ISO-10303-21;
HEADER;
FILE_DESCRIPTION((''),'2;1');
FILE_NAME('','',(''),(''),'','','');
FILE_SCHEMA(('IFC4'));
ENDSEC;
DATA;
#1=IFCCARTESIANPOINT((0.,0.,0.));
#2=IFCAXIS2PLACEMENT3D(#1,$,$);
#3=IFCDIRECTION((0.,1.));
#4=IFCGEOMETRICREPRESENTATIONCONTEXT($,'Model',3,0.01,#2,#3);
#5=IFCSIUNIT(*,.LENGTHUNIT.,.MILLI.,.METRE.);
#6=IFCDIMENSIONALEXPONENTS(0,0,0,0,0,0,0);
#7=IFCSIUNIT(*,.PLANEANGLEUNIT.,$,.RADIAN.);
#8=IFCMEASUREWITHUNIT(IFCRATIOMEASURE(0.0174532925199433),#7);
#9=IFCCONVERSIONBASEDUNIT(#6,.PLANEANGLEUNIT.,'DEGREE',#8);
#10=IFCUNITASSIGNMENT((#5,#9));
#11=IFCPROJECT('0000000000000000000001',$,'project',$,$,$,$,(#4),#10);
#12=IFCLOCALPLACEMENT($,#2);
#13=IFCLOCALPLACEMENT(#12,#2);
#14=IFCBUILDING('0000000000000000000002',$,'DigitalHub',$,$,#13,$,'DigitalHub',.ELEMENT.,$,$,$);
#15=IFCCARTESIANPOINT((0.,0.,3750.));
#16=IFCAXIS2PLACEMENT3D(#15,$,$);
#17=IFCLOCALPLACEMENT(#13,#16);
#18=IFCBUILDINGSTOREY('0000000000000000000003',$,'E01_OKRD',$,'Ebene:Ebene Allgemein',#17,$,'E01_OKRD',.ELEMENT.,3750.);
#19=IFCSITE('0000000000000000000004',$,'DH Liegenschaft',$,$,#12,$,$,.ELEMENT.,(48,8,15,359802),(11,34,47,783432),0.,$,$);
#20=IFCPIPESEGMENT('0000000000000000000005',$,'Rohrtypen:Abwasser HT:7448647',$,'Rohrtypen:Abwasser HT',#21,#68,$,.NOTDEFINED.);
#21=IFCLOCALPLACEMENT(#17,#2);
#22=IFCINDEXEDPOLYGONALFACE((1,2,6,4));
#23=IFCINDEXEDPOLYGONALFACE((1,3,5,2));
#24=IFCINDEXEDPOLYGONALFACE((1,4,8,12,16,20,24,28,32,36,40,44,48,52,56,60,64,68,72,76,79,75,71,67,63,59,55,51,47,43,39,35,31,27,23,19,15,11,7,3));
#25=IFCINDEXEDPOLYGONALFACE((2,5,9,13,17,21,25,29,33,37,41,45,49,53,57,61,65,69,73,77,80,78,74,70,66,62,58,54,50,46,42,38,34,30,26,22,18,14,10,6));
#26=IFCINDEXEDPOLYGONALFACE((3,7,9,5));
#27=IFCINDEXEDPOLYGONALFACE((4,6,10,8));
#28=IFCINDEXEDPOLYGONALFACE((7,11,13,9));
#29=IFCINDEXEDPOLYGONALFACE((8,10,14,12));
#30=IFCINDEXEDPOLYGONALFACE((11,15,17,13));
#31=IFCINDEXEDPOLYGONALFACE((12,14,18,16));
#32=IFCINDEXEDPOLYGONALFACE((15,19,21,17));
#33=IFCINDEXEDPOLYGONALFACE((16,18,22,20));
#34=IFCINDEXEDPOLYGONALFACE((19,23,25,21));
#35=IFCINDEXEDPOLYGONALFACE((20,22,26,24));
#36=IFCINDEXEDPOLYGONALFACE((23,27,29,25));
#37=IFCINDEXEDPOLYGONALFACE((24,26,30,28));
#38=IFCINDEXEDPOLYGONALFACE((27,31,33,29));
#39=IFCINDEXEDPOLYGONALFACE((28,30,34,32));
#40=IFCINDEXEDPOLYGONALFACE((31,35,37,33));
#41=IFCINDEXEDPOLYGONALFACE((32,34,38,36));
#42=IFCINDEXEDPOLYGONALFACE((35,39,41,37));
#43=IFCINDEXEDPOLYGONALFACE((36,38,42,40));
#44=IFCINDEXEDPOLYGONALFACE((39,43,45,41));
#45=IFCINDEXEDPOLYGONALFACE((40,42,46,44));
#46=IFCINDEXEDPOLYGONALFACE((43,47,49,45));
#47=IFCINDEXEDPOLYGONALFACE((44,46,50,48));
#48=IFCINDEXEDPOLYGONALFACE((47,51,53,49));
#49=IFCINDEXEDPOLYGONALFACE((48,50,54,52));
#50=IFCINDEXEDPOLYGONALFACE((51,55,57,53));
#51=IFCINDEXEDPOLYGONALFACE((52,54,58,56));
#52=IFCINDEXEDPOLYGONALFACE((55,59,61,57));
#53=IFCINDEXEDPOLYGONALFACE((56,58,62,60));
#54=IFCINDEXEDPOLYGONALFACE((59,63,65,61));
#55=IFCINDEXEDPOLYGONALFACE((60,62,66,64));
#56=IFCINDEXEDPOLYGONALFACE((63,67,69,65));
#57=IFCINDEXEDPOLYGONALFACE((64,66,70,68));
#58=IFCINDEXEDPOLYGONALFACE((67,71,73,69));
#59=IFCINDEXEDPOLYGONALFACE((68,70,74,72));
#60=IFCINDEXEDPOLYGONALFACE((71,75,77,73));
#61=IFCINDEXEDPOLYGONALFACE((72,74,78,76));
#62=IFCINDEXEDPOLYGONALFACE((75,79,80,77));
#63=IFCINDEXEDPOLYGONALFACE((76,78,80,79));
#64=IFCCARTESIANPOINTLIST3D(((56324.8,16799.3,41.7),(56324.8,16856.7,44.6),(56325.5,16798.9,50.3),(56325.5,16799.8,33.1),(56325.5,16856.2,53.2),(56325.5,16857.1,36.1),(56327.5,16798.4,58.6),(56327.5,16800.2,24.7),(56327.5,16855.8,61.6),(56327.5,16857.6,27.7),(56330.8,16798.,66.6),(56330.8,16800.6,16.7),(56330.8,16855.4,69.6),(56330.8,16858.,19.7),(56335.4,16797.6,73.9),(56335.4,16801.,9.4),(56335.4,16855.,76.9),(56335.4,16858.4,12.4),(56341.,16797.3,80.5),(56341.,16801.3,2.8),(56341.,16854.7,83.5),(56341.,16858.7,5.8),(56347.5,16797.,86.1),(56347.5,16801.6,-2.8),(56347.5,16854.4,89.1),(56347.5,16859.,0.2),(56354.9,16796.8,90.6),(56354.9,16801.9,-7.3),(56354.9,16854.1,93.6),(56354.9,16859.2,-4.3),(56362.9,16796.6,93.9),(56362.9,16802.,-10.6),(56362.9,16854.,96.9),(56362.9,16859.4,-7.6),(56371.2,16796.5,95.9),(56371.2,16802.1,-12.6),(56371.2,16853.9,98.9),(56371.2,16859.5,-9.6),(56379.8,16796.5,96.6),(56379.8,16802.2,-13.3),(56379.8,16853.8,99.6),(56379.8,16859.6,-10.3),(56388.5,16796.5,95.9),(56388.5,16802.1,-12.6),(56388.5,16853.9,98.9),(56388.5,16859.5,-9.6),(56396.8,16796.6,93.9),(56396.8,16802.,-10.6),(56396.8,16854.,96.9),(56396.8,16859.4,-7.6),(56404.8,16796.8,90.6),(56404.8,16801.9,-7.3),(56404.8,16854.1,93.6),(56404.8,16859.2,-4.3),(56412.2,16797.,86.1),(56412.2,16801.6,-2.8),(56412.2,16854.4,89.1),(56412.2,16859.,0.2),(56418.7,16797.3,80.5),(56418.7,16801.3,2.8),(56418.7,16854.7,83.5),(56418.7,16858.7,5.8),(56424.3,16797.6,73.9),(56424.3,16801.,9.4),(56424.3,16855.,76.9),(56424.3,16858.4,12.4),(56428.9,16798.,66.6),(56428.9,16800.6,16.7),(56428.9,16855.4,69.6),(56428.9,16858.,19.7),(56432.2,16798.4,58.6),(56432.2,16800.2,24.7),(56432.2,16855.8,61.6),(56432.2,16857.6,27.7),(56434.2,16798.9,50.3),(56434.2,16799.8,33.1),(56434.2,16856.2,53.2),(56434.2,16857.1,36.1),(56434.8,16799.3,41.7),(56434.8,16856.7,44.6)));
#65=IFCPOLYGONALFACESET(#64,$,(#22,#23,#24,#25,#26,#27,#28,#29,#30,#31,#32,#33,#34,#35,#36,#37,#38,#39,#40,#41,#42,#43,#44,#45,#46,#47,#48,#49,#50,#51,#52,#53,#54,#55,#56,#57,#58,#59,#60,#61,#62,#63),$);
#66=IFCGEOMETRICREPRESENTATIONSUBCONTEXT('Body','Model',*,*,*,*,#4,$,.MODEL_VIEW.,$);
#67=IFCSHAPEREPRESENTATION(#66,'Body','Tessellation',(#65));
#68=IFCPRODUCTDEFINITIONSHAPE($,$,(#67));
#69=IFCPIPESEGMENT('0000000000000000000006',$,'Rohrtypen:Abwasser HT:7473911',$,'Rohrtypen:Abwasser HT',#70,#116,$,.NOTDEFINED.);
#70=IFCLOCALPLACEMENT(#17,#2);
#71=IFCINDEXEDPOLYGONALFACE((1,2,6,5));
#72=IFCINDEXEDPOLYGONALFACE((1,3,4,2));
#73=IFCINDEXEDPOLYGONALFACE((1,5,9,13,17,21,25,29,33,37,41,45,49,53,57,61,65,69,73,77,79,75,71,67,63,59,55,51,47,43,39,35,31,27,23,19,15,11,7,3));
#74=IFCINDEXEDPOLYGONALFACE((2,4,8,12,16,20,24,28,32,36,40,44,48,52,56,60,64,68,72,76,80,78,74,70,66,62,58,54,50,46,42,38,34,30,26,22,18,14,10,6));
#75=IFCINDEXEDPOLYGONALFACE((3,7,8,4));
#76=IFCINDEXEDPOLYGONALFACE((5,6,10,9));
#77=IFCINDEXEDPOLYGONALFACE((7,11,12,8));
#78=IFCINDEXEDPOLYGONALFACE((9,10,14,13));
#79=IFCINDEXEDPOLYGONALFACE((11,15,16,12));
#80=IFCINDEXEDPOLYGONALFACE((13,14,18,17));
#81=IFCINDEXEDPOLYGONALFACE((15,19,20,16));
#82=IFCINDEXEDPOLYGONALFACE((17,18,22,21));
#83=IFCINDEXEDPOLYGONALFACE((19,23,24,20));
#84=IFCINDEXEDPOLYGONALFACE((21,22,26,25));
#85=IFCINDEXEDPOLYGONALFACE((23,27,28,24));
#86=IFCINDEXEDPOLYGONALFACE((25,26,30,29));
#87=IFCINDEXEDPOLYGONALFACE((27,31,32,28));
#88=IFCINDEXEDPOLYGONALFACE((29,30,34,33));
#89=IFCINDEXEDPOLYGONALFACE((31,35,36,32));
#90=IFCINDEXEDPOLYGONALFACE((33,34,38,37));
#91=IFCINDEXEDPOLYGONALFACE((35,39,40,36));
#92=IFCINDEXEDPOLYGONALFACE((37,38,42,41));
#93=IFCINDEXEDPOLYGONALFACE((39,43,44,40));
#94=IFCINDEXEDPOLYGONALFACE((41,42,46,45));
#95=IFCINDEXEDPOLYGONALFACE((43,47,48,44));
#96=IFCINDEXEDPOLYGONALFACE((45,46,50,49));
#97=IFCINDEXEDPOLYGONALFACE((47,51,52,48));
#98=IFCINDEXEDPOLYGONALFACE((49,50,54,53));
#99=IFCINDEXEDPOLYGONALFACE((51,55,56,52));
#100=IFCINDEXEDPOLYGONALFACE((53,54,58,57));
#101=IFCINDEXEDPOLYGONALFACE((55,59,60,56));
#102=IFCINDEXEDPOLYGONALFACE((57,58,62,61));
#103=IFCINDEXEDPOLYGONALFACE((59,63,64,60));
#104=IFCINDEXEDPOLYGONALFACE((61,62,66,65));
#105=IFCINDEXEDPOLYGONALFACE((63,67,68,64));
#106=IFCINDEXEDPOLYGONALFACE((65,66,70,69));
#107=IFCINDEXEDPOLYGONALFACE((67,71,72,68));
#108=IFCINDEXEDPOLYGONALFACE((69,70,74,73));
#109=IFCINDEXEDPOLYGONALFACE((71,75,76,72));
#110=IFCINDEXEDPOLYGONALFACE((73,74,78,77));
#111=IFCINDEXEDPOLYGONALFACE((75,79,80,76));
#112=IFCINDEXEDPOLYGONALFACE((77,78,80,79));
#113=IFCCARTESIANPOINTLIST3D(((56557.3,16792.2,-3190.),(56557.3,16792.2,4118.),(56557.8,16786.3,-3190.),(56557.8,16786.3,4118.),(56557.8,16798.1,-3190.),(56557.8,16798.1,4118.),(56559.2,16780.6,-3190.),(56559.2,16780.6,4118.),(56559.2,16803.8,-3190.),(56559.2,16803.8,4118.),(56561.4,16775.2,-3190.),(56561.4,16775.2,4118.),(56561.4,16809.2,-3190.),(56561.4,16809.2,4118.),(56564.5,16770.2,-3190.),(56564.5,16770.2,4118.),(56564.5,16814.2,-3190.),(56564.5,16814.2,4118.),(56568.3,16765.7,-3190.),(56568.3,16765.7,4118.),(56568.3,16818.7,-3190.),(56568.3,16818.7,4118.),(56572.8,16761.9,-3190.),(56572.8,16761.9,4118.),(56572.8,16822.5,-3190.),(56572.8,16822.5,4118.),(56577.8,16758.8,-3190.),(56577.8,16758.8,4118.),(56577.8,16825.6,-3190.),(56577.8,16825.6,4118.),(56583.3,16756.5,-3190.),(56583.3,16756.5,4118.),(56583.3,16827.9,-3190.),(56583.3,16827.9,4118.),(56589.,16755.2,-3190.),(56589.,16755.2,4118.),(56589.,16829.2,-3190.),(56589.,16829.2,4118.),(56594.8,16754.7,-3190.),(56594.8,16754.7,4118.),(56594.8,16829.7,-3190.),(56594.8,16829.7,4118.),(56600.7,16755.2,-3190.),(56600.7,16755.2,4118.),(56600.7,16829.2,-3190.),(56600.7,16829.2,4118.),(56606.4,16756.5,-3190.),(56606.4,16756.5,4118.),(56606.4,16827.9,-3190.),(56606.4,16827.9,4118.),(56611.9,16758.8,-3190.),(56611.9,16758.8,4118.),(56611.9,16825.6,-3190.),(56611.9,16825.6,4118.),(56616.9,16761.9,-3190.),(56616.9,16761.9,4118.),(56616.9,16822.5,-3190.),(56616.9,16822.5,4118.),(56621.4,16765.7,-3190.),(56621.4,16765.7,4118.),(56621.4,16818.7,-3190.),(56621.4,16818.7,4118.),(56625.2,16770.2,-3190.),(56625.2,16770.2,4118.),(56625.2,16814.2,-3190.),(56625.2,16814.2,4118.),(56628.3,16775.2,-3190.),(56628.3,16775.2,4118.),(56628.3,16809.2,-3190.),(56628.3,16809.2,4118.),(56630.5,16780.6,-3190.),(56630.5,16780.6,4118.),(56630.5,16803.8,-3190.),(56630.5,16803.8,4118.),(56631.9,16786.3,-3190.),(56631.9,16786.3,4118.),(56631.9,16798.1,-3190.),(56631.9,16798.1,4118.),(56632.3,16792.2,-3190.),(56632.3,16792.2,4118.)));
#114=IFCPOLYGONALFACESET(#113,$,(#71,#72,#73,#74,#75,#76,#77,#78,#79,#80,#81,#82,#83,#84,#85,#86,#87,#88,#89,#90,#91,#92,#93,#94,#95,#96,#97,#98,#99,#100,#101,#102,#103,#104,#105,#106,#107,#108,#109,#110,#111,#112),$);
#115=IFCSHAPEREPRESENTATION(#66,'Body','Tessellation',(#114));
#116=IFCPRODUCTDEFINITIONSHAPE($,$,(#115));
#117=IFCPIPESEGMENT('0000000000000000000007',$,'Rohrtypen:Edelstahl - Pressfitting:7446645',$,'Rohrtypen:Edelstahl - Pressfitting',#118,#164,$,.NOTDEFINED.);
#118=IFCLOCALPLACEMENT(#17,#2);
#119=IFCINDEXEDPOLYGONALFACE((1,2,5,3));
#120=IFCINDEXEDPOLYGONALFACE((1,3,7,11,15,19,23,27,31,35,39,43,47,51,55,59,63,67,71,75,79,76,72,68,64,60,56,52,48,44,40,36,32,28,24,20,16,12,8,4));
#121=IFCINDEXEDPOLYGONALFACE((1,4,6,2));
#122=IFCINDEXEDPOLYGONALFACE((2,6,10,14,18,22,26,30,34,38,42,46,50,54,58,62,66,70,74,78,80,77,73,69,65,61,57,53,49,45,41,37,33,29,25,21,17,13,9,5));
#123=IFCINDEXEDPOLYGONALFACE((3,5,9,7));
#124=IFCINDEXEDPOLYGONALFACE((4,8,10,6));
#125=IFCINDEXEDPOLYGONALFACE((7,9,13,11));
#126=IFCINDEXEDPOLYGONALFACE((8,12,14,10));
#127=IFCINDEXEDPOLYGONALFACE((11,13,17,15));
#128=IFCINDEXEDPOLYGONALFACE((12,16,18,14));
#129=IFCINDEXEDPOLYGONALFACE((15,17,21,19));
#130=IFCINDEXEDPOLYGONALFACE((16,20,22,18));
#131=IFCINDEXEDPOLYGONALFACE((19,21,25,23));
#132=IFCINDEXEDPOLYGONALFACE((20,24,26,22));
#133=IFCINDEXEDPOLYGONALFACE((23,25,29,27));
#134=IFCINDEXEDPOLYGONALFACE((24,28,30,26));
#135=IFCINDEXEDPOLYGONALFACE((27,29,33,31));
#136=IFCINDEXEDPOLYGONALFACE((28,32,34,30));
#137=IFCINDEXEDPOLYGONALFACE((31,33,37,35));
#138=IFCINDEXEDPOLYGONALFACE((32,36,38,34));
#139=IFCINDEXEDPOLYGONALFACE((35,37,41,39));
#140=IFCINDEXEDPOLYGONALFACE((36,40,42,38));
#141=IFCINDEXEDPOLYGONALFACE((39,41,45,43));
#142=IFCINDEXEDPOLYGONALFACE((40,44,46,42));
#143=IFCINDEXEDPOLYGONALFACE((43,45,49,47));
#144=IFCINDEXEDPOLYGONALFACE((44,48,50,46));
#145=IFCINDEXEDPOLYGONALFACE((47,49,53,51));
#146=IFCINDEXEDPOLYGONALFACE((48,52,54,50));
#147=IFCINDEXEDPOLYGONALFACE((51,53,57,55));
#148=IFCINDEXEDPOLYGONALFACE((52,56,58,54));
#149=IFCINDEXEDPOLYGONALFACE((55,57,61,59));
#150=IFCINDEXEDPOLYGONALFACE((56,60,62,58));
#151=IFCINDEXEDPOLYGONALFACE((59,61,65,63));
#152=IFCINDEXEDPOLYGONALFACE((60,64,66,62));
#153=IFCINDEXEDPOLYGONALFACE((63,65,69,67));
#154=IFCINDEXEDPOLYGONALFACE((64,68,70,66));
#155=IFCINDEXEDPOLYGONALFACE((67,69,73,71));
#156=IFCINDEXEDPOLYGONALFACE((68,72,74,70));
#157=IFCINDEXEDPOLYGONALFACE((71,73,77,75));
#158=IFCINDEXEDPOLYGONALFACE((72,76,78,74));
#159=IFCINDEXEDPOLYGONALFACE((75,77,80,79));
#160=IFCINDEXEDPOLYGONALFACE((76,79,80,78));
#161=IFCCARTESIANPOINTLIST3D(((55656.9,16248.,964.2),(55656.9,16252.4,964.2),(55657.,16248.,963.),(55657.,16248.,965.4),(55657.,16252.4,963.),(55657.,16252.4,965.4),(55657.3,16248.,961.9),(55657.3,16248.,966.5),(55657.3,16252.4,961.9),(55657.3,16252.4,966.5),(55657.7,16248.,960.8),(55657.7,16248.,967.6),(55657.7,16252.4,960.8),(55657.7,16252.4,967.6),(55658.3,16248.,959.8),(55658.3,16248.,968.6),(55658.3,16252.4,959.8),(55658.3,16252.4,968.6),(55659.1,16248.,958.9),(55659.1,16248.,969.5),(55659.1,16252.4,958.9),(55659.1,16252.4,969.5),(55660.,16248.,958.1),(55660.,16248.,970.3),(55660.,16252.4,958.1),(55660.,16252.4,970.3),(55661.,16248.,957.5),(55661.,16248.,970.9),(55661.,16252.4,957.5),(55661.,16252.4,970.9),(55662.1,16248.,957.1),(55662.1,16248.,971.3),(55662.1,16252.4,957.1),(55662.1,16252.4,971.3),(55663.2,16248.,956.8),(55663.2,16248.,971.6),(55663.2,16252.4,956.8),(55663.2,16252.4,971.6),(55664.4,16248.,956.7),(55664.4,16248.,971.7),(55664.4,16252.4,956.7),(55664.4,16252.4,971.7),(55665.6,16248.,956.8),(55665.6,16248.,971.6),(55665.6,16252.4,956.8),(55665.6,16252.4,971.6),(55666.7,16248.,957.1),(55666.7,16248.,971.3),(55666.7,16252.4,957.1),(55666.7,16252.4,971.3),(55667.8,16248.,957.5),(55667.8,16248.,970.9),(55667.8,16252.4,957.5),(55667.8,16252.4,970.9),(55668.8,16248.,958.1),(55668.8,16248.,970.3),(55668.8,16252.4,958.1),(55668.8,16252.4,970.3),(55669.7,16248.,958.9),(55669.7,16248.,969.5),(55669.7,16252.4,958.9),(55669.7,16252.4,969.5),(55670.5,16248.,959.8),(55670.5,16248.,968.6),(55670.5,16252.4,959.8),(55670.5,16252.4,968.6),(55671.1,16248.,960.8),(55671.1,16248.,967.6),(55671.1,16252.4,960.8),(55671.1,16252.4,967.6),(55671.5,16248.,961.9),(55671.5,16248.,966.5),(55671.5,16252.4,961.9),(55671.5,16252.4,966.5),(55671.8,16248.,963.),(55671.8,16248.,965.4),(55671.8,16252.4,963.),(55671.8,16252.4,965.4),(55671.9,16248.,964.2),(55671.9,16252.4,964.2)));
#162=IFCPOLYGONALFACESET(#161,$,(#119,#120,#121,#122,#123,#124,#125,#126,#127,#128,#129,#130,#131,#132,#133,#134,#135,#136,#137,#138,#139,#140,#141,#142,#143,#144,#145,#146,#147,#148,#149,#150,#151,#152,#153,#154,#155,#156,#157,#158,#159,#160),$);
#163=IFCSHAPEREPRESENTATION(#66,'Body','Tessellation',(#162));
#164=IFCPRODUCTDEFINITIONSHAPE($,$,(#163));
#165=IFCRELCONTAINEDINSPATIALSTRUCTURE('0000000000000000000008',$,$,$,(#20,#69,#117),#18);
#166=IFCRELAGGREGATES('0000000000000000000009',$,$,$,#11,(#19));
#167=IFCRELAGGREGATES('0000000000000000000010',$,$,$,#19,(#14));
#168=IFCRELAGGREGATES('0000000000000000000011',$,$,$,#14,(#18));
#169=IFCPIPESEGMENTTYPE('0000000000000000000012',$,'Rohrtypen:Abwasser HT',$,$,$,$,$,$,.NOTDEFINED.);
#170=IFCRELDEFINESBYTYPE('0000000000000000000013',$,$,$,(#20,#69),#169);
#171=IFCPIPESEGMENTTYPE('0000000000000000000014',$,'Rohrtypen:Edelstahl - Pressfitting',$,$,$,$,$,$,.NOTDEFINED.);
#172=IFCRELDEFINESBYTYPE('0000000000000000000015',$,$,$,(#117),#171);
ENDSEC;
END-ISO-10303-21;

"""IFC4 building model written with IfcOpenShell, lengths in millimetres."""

from ifc_helpers import new_model, entity, si_unit, converted_unit, direction, frame, origin, place, context, subcontext, project, spatial, indexed_curve, outline, extrude, type_object, element, save


model = new_model("IFC4")

# Units and contexts
model_context = context("Model", 3, precision=0.01, world=origin(), true_north=direction((0.0, 1.0)))
body_context = subcontext(model_context, "Body", "Model", "MODEL_VIEW")
ifc_project = project(units=[si_unit("LENGTHUNIT", "METRE", prefix="MILLI"), converted_unit("PLANEANGLEUNIT", "DEGREE", entity("IfcRatioMeasure", 0.0174532925199433), si_unit("PLANEANGLEUNIT", "RADIAN"), dimensions=[0, 0, 0, 0, 0, 0, 0])], contexts=[model_context])

# Site, building, storey
site_placement = place(None, origin())
site = spatial("IfcSite", under=ifc_project, at=site_placement, Name="DH Liegenschaft", CompositionType="ELEMENT", RefLatitude=(48, 8, 15, 359802), RefLongitude=(11, 34, 47, 783432), RefElevation=0.0)
building_placement = place(site_placement, origin())
building = spatial("IfcBuilding", under=site, at=building_placement, Name="DigitalHub", LongName="DigitalHub", CompositionType="ELEMENT")
storey_placement = place(building_placement, frame((0.0, 0.0, 3750.0)))
storey = spatial("IfcBuildingStorey", under=building, at=storey_placement, Name="E01_OKRD", ObjectType="Ebene:Ebene Allgemein", LongName="E01_OKRD", CompositionType="ELEMENT", Elevation=3750.0)

# Pipe segments
pipe_segment_type_1 = type_object("IfcPipeSegmentType", Name="Rohrtypen:Abwasser HT", PredefinedType="NOTDEFINED")
pipe_segment_1_placement = place(storey_placement, frame((56323.3, 16794.9, -14.9)))
element("IfcPipeSegment", 1, at=pipe_segment_1_placement, inside=storey, type_object=pipe_segment_type_1, Name="Rohrtypen:Abwasser HT:7448647", ObjectType="Rohrtypen:Abwasser HT", PredefinedType="NOTDEFINED", context=body_context, shape_type="SweptSolid", body=[
    extrude(outline(indexed_curve([(55.0, 0.0), (54.3, 8.6), (52.3, 17.0), (49.0, 25.0), (44.5, 32.3), (38.9, 38.9), (32.3, 44.5), (25.0, 49.0), (17.0, 52.3), (8.6, 54.3), (0.0, 55.0), (-8.6, 54.3), (-17.0, 52.3), (-25.0, 49.0), (-32.3, 44.5), (-38.9, 38.9), (-44.5, 32.3), (-49.0, 25.0), (-52.3, 17.0), (-54.3, 8.6), (-55.0, 0.0), (-54.3, -8.6), (-52.3, -17.0), (-49.0, -25.0), (-44.5, -32.3), (-38.9, -38.9), (-32.3, -44.5), (-25.0, -49.0), (-17.0, -52.3), (-8.6, -54.3), (0.0, -55.0), (8.6, -54.3), (17.0, -52.3), (25.0, -49.0), (32.3, -44.5), (38.9, -38.9), (44.5, -32.3), (49.0, -25.0), (52.3, -17.0), (54.3, -8.6), (55.0, 0.0)], self_intersect=False)), frame((56.6, 4.5, 56.5), z_axis=(0.000001, 0.998647, 0.051999), x_axis=(-1.0, 0.000001, 0.0)), (0.0, 0.0, 1.0), 57.4),
])
pipe_segment_2_placement = place(storey_placement, frame((56555.8, 16753.1, -3190.0)))
element("IfcPipeSegment", 2, at=pipe_segment_2_placement, inside=storey, type_object=pipe_segment_type_1, Name="Rohrtypen:Abwasser HT:7473911", ObjectType="Rohrtypen:Abwasser HT", PredefinedType="NOTDEFINED", context=body_context, shape_type="SweptSolid", body=[
    extrude(outline(indexed_curve([(37.5, 0.0), (37.0, 5.9), (35.7, 11.6), (33.4, 17.0), (30.3, 22.0), (26.5, 26.5), (22.0, 30.3), (17.0, 33.4), (11.6, 35.7), (5.9, 37.0), (0.0, 37.5), (-5.9, 37.0), (-11.6, 35.7), (-17.0, 33.4), (-22.0, 30.3), (-26.5, 26.5), (-30.3, 22.0), (-33.4, 17.0), (-35.7, 11.6), (-37.0, 5.9), (-37.5, 0.0), (-37.0, -5.9), (-35.7, -11.6), (-33.4, -17.0), (-30.3, -22.0), (-26.5, -26.5), (-22.0, -30.3), (-17.0, -33.4), (-11.6, -35.7), (-5.9, -37.0), (0.0, -37.5), (5.9, -37.0), (11.6, -35.7), (17.0, -33.4), (22.0, -30.3), (26.5, -26.5), (30.3, -22.0), (33.4, -17.0), (35.7, -11.6), (37.0, -5.9), (37.5, 0.0)], self_intersect=False)), frame((39.1, 39.1, 0.0), z_axis=(0.0, 0.0, 1.0), x_axis=(-1.0, 0.0, 0.0)), (0.0, 0.0, 1.0), 7308.0),
])
pipe_segment_type_2 = type_object("IfcPipeSegmentType", Name="Rohrtypen:Edelstahl - Pressfitting", PredefinedType="NOTDEFINED")
pipe_segment_3_placement = place(storey_placement, frame((55655.3, 16248.0, 955.1)))
element("IfcPipeSegment", 3, at=pipe_segment_3_placement, inside=storey, type_object=pipe_segment_type_2, Name="Rohrtypen:Edelstahl - Pressfitting:7446645", ObjectType="Rohrtypen:Edelstahl - Pressfitting", PredefinedType="NOTDEFINED", context=body_context, shape_type="SweptSolid", body=[
    extrude(outline(indexed_curve([(7.5, 0.0), (7.4, 1.2), (7.1, 2.3), (6.7, 3.4), (6.1, 4.4), (5.3, 5.3), (4.4, 6.1), (3.4, 6.7), (2.3, 7.1), (1.2, 7.4), (0.0, 7.5), (-1.2, 7.4), (-2.3, 7.1), (-3.4, 6.7), (-4.4, 6.1), (-5.3, 5.3), (-6.1, 4.4), (-6.7, 3.4), (-7.1, 2.3), (-7.4, 1.2), (-7.5, 0.0), (-7.4, -1.2), (-7.1, -2.3), (-6.7, -3.4), (-6.1, -4.4), (-5.3, -5.3), (-4.4, -6.1), (-3.4, -6.7), (-2.3, -7.1), (-1.2, -7.4), (0.0, -7.5), (1.2, -7.4), (2.3, -7.1), (3.4, -6.7), (4.4, -6.1), (5.3, -5.3), (6.1, -4.4), (6.7, -3.4), (7.1, -2.3), (7.4, -1.2), (7.5, 0.0)], self_intersect=False)), frame((9.1, 0.0, 9.1), z_axis=(0.0, 1.0, 0.0), x_axis=(1.0, 0.0, 0.0)), (0.0, 0.0, 1.0), 4.4),
])

save(model, "model.ifc")
